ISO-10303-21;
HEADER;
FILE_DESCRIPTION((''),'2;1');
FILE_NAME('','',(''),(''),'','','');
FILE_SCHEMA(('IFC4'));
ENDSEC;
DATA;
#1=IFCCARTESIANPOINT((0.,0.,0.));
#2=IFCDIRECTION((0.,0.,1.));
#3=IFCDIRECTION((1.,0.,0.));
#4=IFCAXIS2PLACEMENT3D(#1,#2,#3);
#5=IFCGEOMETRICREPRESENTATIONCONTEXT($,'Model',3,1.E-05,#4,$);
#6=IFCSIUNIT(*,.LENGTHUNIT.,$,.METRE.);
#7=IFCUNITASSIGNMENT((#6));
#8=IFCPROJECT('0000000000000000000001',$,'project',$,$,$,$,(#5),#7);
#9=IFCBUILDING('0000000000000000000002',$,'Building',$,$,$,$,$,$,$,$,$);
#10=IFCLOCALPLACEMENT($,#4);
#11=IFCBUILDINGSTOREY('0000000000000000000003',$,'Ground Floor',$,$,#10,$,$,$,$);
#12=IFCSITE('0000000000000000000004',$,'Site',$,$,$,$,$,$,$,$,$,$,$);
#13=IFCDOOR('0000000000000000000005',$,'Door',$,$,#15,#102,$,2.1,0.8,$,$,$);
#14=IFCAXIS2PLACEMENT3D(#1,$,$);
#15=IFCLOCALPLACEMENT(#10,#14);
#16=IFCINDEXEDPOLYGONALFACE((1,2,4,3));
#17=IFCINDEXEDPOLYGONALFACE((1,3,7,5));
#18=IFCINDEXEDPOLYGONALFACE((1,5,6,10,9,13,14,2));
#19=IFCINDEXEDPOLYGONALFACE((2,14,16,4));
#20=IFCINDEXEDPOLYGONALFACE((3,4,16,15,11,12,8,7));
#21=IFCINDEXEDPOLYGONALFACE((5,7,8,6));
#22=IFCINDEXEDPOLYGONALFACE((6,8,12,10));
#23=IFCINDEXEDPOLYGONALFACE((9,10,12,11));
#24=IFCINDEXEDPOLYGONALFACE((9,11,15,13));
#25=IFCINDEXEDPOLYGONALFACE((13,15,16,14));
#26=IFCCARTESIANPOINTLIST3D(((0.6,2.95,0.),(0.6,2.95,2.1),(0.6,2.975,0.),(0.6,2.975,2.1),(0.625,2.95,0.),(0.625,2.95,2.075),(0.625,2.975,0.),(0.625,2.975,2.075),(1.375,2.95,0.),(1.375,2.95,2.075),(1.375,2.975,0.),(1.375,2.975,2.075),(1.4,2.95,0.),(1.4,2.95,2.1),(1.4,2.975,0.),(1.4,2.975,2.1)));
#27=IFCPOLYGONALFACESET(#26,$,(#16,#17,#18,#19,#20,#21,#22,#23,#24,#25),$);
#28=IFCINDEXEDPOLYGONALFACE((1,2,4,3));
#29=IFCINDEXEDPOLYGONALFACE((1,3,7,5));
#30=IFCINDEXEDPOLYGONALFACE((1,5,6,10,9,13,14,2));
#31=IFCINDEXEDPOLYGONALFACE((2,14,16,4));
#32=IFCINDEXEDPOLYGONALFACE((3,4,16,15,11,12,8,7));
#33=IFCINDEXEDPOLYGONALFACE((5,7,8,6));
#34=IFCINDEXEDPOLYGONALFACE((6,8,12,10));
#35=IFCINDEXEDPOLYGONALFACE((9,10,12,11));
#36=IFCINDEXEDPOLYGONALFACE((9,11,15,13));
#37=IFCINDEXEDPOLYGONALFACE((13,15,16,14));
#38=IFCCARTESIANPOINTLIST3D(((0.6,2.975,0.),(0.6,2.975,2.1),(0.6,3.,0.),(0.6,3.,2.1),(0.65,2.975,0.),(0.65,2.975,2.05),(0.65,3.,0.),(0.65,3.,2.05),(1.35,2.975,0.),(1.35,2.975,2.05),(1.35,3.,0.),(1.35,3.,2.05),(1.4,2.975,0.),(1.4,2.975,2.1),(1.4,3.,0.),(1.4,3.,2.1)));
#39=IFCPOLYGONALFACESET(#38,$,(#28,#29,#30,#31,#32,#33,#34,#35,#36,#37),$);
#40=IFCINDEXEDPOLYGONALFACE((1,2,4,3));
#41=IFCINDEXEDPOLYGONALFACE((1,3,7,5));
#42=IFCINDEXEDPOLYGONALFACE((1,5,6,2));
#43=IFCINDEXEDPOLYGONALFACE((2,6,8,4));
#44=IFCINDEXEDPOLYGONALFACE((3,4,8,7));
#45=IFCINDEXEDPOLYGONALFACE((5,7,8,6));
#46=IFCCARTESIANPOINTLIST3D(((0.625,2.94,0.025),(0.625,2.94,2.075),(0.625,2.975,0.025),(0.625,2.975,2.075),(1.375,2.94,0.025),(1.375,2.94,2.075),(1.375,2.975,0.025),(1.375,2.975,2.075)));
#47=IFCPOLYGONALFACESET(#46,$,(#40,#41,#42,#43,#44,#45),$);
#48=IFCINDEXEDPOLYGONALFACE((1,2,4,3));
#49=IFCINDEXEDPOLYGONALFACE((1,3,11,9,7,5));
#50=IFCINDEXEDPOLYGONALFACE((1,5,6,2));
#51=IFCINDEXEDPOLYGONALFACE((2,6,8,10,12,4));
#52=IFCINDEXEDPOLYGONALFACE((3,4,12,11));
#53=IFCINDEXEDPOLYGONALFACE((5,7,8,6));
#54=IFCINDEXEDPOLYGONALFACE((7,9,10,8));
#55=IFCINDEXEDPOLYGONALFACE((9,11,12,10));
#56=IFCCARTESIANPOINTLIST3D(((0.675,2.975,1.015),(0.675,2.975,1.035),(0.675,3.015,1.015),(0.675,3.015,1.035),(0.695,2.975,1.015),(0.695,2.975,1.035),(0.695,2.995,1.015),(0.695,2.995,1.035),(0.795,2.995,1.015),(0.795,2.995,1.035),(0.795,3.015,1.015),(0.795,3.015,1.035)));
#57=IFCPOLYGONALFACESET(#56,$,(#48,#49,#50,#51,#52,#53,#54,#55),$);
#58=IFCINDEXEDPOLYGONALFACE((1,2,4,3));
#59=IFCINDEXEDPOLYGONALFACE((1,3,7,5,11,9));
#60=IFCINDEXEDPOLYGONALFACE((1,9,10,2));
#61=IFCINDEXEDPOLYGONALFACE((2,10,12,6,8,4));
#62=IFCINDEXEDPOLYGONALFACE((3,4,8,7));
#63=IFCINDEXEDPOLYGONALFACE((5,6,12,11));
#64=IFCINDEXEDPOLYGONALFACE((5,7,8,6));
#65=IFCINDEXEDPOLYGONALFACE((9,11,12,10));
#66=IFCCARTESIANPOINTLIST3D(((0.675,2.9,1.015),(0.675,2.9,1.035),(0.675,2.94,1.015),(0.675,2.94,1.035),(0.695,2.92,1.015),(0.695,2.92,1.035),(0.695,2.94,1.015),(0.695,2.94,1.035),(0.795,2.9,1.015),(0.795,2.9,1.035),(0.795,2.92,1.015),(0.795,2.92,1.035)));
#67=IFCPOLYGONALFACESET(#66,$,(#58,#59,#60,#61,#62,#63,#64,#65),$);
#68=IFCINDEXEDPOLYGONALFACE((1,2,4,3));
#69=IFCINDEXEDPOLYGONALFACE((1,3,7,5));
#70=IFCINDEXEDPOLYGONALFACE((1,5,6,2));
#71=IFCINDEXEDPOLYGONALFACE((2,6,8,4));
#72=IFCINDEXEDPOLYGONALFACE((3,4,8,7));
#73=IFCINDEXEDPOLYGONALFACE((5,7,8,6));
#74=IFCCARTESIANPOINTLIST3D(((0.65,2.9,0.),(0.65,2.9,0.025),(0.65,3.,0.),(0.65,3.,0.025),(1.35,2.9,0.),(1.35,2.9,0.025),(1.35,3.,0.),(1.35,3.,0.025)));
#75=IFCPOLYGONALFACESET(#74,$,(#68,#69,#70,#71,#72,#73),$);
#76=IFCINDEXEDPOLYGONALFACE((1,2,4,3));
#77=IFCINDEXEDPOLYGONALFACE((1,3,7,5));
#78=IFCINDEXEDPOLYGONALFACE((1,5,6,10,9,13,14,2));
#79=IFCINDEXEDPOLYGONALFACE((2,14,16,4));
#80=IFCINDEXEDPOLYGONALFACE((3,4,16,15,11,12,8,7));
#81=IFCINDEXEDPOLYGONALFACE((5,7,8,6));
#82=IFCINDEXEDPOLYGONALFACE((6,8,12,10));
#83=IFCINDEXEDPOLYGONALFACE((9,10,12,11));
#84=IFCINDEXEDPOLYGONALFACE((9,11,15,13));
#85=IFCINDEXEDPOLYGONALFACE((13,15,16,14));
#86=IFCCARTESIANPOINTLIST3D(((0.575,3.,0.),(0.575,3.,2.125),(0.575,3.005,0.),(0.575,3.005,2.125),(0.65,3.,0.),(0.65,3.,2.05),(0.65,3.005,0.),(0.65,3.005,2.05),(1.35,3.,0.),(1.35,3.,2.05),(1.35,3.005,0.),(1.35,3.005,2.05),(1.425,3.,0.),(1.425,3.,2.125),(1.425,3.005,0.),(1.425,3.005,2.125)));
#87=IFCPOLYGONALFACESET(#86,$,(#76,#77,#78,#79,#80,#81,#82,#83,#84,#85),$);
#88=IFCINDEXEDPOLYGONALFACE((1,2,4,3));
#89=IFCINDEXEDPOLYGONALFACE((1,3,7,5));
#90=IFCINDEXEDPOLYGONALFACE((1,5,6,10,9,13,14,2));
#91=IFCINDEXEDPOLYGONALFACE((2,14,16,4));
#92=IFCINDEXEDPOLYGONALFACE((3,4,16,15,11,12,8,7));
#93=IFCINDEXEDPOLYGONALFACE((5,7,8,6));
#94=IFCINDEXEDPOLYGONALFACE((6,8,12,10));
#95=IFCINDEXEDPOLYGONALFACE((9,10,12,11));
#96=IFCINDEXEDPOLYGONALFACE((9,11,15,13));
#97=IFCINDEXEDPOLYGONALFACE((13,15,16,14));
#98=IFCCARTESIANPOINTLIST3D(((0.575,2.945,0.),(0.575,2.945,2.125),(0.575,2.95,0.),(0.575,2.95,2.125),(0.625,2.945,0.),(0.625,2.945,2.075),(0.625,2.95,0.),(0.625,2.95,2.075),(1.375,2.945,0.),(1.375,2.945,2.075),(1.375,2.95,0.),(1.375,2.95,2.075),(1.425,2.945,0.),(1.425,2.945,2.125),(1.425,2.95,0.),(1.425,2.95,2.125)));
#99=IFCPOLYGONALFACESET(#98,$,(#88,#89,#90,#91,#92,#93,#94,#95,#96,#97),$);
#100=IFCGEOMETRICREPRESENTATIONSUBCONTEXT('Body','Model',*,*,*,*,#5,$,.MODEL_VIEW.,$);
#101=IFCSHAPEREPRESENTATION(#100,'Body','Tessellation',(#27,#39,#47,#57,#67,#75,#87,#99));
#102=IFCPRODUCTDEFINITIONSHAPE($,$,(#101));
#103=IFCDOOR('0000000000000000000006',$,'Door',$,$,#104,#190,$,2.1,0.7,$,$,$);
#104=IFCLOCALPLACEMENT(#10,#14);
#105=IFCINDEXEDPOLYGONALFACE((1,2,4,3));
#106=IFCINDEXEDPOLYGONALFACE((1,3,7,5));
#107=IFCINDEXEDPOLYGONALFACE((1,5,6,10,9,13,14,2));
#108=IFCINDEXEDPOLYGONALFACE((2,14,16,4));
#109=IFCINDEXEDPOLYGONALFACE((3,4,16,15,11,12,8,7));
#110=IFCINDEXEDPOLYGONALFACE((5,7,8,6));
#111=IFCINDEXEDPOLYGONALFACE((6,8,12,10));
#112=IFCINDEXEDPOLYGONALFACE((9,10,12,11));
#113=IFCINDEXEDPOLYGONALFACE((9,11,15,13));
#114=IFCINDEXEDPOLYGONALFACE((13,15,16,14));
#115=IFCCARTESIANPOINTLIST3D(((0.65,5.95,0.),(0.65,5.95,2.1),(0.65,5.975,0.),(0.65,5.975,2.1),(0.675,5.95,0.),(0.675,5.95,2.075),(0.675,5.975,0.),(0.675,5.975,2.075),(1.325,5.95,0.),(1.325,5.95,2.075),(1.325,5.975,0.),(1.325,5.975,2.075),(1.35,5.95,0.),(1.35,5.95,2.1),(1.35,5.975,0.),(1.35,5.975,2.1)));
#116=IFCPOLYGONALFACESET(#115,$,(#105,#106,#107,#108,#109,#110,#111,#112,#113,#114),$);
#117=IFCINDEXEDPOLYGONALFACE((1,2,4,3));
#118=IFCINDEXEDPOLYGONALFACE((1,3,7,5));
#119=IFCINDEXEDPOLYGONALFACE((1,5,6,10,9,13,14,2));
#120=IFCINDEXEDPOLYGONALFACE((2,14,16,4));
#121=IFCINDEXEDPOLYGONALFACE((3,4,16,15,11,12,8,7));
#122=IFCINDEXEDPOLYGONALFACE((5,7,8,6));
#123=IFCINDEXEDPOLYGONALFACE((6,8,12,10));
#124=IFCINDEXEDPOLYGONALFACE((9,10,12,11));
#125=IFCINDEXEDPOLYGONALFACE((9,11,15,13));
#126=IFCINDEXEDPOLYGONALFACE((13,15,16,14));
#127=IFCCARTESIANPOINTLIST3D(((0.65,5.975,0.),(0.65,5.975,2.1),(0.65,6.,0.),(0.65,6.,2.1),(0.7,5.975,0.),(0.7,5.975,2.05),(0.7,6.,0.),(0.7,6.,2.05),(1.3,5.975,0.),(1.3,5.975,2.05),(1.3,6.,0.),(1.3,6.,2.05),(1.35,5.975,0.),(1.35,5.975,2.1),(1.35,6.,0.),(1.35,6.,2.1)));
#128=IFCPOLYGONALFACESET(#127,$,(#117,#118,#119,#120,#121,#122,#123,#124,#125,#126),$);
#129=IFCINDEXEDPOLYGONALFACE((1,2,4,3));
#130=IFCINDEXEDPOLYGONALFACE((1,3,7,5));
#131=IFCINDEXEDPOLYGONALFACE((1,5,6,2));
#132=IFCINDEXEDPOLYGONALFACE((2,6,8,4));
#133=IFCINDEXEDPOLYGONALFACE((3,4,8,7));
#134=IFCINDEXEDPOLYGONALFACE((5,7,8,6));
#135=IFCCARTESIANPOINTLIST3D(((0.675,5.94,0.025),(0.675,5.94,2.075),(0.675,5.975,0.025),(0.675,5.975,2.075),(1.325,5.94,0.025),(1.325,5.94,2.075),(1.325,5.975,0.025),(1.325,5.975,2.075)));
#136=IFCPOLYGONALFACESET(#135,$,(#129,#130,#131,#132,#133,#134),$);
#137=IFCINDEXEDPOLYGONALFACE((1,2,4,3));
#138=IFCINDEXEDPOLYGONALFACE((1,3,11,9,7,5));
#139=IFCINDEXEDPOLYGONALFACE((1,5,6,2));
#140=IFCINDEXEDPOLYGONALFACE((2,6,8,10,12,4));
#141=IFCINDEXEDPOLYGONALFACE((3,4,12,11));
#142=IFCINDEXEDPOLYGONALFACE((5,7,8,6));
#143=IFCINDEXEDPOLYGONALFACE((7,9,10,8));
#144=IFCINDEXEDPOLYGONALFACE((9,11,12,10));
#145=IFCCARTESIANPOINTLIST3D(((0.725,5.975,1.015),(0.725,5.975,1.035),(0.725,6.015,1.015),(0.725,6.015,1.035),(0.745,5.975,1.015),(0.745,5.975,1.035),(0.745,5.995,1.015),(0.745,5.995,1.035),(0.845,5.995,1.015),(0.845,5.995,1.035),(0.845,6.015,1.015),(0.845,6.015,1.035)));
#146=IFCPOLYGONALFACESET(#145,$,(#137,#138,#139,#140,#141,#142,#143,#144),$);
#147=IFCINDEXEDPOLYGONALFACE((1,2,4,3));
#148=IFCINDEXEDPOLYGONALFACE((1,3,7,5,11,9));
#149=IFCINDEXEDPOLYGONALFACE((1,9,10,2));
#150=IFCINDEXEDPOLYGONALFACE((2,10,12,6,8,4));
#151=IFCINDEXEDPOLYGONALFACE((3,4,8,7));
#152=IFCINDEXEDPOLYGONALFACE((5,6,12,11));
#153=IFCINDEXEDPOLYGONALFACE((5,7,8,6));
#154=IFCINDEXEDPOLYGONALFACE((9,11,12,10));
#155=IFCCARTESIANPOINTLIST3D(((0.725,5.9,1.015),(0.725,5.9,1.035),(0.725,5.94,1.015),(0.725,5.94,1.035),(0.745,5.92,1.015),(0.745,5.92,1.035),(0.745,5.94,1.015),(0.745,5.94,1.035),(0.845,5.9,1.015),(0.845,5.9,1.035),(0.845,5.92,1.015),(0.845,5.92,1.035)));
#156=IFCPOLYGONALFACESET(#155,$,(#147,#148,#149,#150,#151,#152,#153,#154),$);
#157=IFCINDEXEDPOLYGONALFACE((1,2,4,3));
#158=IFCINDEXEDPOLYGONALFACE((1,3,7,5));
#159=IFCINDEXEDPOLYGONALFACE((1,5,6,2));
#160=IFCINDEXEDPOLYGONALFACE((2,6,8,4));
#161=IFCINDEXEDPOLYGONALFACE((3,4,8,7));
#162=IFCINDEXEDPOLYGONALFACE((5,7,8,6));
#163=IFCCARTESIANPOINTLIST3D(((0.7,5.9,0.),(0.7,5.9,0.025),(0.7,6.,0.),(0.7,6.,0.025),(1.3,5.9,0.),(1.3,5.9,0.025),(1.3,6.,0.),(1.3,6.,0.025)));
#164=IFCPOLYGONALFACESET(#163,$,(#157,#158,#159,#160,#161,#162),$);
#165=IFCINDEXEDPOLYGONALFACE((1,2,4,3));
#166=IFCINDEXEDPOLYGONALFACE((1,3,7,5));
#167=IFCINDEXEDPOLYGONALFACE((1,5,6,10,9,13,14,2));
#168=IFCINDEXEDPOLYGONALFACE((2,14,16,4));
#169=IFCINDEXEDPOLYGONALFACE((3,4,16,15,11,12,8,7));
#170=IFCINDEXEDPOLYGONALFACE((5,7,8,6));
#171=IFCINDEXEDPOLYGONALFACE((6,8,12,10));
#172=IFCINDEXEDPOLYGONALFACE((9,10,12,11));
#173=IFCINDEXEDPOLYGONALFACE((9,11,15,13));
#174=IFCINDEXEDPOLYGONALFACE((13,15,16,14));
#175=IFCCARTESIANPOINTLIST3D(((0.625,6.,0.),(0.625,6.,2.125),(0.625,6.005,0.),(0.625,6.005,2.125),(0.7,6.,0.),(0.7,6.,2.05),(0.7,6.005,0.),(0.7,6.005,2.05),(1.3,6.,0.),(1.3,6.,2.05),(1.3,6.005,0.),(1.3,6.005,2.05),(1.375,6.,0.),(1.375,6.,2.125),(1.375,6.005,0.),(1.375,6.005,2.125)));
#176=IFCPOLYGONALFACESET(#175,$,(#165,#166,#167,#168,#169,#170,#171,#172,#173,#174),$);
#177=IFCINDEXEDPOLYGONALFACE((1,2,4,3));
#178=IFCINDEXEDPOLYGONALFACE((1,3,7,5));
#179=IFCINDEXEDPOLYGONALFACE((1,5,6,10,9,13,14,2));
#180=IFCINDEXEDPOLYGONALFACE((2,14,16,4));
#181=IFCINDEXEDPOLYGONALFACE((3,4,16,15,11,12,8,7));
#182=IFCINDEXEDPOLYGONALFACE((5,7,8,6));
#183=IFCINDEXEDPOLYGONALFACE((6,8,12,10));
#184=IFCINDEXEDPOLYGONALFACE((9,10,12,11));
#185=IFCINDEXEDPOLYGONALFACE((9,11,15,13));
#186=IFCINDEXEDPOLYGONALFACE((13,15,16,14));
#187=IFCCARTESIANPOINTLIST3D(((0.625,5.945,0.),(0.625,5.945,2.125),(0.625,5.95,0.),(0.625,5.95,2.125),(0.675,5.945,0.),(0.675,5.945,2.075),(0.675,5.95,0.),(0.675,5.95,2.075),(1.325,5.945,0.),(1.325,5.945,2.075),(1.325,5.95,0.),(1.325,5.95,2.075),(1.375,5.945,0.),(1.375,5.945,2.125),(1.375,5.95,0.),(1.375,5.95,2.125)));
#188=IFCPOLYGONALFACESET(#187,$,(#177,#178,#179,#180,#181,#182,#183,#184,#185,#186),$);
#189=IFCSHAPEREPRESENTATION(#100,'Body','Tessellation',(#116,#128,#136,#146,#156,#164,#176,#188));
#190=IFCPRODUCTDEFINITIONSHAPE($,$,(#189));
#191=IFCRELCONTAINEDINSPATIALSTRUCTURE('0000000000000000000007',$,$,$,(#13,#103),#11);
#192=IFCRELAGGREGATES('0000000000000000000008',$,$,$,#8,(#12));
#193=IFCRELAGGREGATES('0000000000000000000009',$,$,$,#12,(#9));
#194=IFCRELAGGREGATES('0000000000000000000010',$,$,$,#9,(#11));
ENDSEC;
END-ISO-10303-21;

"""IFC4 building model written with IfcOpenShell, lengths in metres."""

from ifc_helpers import new_model, si_unit, frame, origin_with_axes, place, context, subcontext, project, spatial, line, indexed_curve, outline, extrude, element, save


model = new_model("IFC4")

# Units and contexts
model_context = context("Model", 3, precision=1e-05, world=origin_with_axes())
body_context = subcontext(model_context, "Body", "Model", "MODEL_VIEW")
ifc_project = project(units=[si_unit("LENGTHUNIT", "METRE")], contexts=[model_context])

# Site, building, storey
site = spatial("IfcSite", under=ifc_project, Name="Site")
building = spatial("IfcBuilding", under=site, Name="Building")
storey_placement = place(None, origin_with_axes())
storey = spatial("IfcBuildingStorey", under=building, at=storey_placement, Name="Ground Floor")

# Doors
door_1_placement = place(storey_placement, frame((1.4, 3.0, 0.0), z_axis=(0.0, 0.0, 1.0), x_axis=(-1.0, 0.0, 0.0)))
element("IfcDoor", 1, at=door_1_placement, inside=storey, Name="Door", OverallHeight=2.1, OverallWidth=0.8, context=body_context, shape_type="SweptSolid", body=[
    extrude(outline(indexed_curve([(0.0, 0.0), (0.0, 2.1), (0.8, 2.1), (0.8, 0.0), (0.775, 0.0), (0.775, 2.075), (0.025, 2.075), (0.025, 0.0)], segments=[line(1, 2, 3, 4, 5, 6, 7, 8, 1)])), frame((0.0, 0.025, 0.0), z_axis=(0.0, -1.0, 0.0), x_axis=(1.0, 0.0, 0.0)), (0.0, 0.0, -1.0), 0.025),
    extrude(outline(indexed_curve([(0.0, 0.0), (0.0, 2.1), (0.8, 2.1), (0.8, 0.0), (0.75, 0.0), (0.75, 2.05), (0.05, 2.05), (0.05, 0.0)], segments=[line(1, 2, 3, 4, 5, 6, 7, 8, 1)])), frame((0.0, 0.0, 0.0), z_axis=(0.0, -1.0, 0.0), x_axis=(1.0, 0.0, 0.0)), (0.0, 0.0, -1.0), 0.025),
    extrude(outline(indexed_curve([(0.0, 0.0), (0.75, 0.0), (0.75, 0.035), (0.0, 0.035)], segments=[line(1, 2, 3, 4, 1)])), frame((0.025, 0.025, 0.025), z_axis=(0.0, 0.0, 1.0), x_axis=(1.0, 0.0, 0.0)), (0.0, 0.0, 1.0), 2.05),
    extrude(outline(indexed_curve([(0.0, 0.0), (0.0, -0.04), (-0.12, -0.04), (-0.12, -0.02), (-0.02, -0.02), (-0.02, 0.0)], segments=[line(1, 2, 3, 4, 5, 6, 1)])), frame((0.725, 0.025, 1.015), z_axis=(0.0, 0.0, 1.0), x_axis=(1.0, 0.0, 0.0)), (0.0, 0.0, 1.0), 0.02),
    extrude(outline(indexed_curve([(0.0, 0.0), (0.0, 0.04), (-0.12, 0.04), (-0.12, 0.02), (-0.02, 0.02), (-0.02, 0.0)], segments=[line(1, 2, 3, 4, 5, 6, 1)])), frame((0.725, 0.06, 1.015), z_axis=(0.0, 0.0, 1.0), x_axis=(1.0, 0.0, 0.0)), (0.0, 0.0, 1.0), 0.02),
    extrude(outline(indexed_curve([(0.0, 0.0), (0.7, 0.0), (0.7, 0.1), (0.0, 0.1)], segments=[line(1, 2, 3, 4, 1)])), frame((0.05, 0.0, 0.0), z_axis=(0.0, 0.0, 1.0), x_axis=(1.0, 0.0, 0.0)), (0.0, 0.0, 1.0), 0.025),
    extrude(outline(indexed_curve([(0.0, 0.0), (0.0, 2.125), (0.85, 2.125), (0.85, 0.0), (0.775, 0.0), (0.775, 2.05), (0.075, 2.05), (0.075, 0.0)], segments=[line(1, 2, 3, 4, 5, 6, 7, 8, 1)])), frame((-0.025, -0.005, 0.0), z_axis=(0.0, -1.0, 0.0), x_axis=(1.0, 0.0, 0.0)), (0.0, 0.0, -1.0), 0.005),
    extrude(outline(indexed_curve([(0.0, 0.0), (0.0, 2.125), (0.85, 2.125), (0.85, 0.0), (0.8, 0.0), (0.8, 2.075), (0.05, 2.075), (0.05, 0.0)], segments=[line(1, 2, 3, 4, 5, 6, 7, 8, 1)])), frame((-0.025, 0.05, 0.0), z_axis=(0.0, -1.0, 0.0), x_axis=(1.0, 0.0, 0.0)), (0.0, 0.0, -1.0), 0.005),
])
door_2_placement = place(storey_placement, frame((1.35, 6.0, 0.0), z_axis=(0.0, 0.0, 1.0), x_axis=(-1.0, 0.0, 0.0)))
element("IfcDoor", 2, at=door_2_placement, inside=storey, Name="Door", OverallHeight=2.1, OverallWidth=0.7, context=body_context, shape_type="SweptSolid", body=[
    extrude(outline(indexed_curve([(0.0, 0.0), (0.0, 2.1), (0.7, 2.1), (0.7, 0.0), (0.675, 0.0), (0.675, 2.075), (0.025, 2.075), (0.025, 0.0)], segments=[line(1, 2, 3, 4, 5, 6, 7, 8, 1)])), frame((0.0, 0.025, 0.0), z_axis=(0.0, -1.0, 0.0), x_axis=(1.0, 0.0, 0.0)), (0.0, 0.0, -1.0), 0.025),
    extrude(outline(indexed_curve([(0.0, 0.0), (0.0, 2.1), (0.7, 2.1), (0.7, 0.0), (0.65, 0.0), (0.65, 2.05), (0.05, 2.05), (0.05, 0.0)], segments=[line(1, 2, 3, 4, 5, 6, 7, 8, 1)])), frame((0.0, 0.0, 0.0), z_axis=(0.0, -1.0, 0.0), x_axis=(1.0, 0.0, 0.0)), (0.0, 0.0, -1.0), 0.025),
    extrude(outline(indexed_curve([(0.0, 0.0), (0.65, 0.0), (0.65, 0.035), (0.0, 0.035)], segments=[line(1, 2, 3, 4, 1)])), frame((0.025, 0.025, 0.025), z_axis=(0.0, 0.0, 1.0), x_axis=(1.0, 0.0, 0.0)), (0.0, 0.0, 1.0), 2.05),
    extrude(outline(indexed_curve([(0.0, 0.0), (0.0, -0.04), (-0.12, -0.04), (-0.12, -0.02), (-0.02, -0.02), (-0.02, 0.0)], segments=[line(1, 2, 3, 4, 5, 6, 1)])), frame((0.625, 0.025, 1.015), z_axis=(0.0, 0.0, 1.0), x_axis=(1.0, 0.0, 0.0)), (0.0, 0.0, 1.0), 0.02),
    extrude(outline(indexed_curve([(0.0, 0.0), (0.0, 0.04), (-0.12, 0.04), (-0.12, 0.02), (-0.02, 0.02), (-0.02, 0.0)], segments=[line(1, 2, 3, 4, 5, 6, 1)])), frame((0.625, 0.06, 1.015), z_axis=(0.0, 0.0, 1.0), x_axis=(1.0, 0.0, 0.0)), (0.0, 0.0, 1.0), 0.02),
    extrude(outline(indexed_curve([(0.0, 0.0), (0.6, 0.0), (0.6, 0.1), (0.0, 0.1)], segments=[line(1, 2, 3, 4, 1)])), frame((0.05, 0.0, 0.0), z_axis=(0.0, 0.0, 1.0), x_axis=(1.0, 0.0, 0.0)), (0.0, 0.0, 1.0), 0.025),
    extrude(outline(indexed_curve([(0.0, 0.0), (0.0, 2.125), (0.75, 2.125), (0.75, 0.0), (0.675, 0.0), (0.675, 2.05), (0.075, 2.05), (0.075, 0.0)], segments=[line(1, 2, 3, 4, 5, 6, 7, 8, 1)])), frame((-0.025, -0.005, 0.0), z_axis=(0.0, -1.0, 0.0), x_axis=(1.0, 0.0, 0.0)), (0.0, 0.0, -1.0), 0.005),
    extrude(outline(indexed_curve([(0.0, 0.0), (0.0, 2.125), (0.75, 2.125), (0.75, 0.0), (0.7, 0.0), (0.7, 2.075), (0.05, 2.075), (0.05, 0.0)], segments=[line(1, 2, 3, 4, 5, 6, 7, 8, 1)])), frame((-0.025, 0.05, 0.0), z_axis=(0.0, -1.0, 0.0), x_axis=(1.0, 0.0, 0.0)), (0.0, 0.0, -1.0), 0.005),
])

save(model, "model.ifc")
